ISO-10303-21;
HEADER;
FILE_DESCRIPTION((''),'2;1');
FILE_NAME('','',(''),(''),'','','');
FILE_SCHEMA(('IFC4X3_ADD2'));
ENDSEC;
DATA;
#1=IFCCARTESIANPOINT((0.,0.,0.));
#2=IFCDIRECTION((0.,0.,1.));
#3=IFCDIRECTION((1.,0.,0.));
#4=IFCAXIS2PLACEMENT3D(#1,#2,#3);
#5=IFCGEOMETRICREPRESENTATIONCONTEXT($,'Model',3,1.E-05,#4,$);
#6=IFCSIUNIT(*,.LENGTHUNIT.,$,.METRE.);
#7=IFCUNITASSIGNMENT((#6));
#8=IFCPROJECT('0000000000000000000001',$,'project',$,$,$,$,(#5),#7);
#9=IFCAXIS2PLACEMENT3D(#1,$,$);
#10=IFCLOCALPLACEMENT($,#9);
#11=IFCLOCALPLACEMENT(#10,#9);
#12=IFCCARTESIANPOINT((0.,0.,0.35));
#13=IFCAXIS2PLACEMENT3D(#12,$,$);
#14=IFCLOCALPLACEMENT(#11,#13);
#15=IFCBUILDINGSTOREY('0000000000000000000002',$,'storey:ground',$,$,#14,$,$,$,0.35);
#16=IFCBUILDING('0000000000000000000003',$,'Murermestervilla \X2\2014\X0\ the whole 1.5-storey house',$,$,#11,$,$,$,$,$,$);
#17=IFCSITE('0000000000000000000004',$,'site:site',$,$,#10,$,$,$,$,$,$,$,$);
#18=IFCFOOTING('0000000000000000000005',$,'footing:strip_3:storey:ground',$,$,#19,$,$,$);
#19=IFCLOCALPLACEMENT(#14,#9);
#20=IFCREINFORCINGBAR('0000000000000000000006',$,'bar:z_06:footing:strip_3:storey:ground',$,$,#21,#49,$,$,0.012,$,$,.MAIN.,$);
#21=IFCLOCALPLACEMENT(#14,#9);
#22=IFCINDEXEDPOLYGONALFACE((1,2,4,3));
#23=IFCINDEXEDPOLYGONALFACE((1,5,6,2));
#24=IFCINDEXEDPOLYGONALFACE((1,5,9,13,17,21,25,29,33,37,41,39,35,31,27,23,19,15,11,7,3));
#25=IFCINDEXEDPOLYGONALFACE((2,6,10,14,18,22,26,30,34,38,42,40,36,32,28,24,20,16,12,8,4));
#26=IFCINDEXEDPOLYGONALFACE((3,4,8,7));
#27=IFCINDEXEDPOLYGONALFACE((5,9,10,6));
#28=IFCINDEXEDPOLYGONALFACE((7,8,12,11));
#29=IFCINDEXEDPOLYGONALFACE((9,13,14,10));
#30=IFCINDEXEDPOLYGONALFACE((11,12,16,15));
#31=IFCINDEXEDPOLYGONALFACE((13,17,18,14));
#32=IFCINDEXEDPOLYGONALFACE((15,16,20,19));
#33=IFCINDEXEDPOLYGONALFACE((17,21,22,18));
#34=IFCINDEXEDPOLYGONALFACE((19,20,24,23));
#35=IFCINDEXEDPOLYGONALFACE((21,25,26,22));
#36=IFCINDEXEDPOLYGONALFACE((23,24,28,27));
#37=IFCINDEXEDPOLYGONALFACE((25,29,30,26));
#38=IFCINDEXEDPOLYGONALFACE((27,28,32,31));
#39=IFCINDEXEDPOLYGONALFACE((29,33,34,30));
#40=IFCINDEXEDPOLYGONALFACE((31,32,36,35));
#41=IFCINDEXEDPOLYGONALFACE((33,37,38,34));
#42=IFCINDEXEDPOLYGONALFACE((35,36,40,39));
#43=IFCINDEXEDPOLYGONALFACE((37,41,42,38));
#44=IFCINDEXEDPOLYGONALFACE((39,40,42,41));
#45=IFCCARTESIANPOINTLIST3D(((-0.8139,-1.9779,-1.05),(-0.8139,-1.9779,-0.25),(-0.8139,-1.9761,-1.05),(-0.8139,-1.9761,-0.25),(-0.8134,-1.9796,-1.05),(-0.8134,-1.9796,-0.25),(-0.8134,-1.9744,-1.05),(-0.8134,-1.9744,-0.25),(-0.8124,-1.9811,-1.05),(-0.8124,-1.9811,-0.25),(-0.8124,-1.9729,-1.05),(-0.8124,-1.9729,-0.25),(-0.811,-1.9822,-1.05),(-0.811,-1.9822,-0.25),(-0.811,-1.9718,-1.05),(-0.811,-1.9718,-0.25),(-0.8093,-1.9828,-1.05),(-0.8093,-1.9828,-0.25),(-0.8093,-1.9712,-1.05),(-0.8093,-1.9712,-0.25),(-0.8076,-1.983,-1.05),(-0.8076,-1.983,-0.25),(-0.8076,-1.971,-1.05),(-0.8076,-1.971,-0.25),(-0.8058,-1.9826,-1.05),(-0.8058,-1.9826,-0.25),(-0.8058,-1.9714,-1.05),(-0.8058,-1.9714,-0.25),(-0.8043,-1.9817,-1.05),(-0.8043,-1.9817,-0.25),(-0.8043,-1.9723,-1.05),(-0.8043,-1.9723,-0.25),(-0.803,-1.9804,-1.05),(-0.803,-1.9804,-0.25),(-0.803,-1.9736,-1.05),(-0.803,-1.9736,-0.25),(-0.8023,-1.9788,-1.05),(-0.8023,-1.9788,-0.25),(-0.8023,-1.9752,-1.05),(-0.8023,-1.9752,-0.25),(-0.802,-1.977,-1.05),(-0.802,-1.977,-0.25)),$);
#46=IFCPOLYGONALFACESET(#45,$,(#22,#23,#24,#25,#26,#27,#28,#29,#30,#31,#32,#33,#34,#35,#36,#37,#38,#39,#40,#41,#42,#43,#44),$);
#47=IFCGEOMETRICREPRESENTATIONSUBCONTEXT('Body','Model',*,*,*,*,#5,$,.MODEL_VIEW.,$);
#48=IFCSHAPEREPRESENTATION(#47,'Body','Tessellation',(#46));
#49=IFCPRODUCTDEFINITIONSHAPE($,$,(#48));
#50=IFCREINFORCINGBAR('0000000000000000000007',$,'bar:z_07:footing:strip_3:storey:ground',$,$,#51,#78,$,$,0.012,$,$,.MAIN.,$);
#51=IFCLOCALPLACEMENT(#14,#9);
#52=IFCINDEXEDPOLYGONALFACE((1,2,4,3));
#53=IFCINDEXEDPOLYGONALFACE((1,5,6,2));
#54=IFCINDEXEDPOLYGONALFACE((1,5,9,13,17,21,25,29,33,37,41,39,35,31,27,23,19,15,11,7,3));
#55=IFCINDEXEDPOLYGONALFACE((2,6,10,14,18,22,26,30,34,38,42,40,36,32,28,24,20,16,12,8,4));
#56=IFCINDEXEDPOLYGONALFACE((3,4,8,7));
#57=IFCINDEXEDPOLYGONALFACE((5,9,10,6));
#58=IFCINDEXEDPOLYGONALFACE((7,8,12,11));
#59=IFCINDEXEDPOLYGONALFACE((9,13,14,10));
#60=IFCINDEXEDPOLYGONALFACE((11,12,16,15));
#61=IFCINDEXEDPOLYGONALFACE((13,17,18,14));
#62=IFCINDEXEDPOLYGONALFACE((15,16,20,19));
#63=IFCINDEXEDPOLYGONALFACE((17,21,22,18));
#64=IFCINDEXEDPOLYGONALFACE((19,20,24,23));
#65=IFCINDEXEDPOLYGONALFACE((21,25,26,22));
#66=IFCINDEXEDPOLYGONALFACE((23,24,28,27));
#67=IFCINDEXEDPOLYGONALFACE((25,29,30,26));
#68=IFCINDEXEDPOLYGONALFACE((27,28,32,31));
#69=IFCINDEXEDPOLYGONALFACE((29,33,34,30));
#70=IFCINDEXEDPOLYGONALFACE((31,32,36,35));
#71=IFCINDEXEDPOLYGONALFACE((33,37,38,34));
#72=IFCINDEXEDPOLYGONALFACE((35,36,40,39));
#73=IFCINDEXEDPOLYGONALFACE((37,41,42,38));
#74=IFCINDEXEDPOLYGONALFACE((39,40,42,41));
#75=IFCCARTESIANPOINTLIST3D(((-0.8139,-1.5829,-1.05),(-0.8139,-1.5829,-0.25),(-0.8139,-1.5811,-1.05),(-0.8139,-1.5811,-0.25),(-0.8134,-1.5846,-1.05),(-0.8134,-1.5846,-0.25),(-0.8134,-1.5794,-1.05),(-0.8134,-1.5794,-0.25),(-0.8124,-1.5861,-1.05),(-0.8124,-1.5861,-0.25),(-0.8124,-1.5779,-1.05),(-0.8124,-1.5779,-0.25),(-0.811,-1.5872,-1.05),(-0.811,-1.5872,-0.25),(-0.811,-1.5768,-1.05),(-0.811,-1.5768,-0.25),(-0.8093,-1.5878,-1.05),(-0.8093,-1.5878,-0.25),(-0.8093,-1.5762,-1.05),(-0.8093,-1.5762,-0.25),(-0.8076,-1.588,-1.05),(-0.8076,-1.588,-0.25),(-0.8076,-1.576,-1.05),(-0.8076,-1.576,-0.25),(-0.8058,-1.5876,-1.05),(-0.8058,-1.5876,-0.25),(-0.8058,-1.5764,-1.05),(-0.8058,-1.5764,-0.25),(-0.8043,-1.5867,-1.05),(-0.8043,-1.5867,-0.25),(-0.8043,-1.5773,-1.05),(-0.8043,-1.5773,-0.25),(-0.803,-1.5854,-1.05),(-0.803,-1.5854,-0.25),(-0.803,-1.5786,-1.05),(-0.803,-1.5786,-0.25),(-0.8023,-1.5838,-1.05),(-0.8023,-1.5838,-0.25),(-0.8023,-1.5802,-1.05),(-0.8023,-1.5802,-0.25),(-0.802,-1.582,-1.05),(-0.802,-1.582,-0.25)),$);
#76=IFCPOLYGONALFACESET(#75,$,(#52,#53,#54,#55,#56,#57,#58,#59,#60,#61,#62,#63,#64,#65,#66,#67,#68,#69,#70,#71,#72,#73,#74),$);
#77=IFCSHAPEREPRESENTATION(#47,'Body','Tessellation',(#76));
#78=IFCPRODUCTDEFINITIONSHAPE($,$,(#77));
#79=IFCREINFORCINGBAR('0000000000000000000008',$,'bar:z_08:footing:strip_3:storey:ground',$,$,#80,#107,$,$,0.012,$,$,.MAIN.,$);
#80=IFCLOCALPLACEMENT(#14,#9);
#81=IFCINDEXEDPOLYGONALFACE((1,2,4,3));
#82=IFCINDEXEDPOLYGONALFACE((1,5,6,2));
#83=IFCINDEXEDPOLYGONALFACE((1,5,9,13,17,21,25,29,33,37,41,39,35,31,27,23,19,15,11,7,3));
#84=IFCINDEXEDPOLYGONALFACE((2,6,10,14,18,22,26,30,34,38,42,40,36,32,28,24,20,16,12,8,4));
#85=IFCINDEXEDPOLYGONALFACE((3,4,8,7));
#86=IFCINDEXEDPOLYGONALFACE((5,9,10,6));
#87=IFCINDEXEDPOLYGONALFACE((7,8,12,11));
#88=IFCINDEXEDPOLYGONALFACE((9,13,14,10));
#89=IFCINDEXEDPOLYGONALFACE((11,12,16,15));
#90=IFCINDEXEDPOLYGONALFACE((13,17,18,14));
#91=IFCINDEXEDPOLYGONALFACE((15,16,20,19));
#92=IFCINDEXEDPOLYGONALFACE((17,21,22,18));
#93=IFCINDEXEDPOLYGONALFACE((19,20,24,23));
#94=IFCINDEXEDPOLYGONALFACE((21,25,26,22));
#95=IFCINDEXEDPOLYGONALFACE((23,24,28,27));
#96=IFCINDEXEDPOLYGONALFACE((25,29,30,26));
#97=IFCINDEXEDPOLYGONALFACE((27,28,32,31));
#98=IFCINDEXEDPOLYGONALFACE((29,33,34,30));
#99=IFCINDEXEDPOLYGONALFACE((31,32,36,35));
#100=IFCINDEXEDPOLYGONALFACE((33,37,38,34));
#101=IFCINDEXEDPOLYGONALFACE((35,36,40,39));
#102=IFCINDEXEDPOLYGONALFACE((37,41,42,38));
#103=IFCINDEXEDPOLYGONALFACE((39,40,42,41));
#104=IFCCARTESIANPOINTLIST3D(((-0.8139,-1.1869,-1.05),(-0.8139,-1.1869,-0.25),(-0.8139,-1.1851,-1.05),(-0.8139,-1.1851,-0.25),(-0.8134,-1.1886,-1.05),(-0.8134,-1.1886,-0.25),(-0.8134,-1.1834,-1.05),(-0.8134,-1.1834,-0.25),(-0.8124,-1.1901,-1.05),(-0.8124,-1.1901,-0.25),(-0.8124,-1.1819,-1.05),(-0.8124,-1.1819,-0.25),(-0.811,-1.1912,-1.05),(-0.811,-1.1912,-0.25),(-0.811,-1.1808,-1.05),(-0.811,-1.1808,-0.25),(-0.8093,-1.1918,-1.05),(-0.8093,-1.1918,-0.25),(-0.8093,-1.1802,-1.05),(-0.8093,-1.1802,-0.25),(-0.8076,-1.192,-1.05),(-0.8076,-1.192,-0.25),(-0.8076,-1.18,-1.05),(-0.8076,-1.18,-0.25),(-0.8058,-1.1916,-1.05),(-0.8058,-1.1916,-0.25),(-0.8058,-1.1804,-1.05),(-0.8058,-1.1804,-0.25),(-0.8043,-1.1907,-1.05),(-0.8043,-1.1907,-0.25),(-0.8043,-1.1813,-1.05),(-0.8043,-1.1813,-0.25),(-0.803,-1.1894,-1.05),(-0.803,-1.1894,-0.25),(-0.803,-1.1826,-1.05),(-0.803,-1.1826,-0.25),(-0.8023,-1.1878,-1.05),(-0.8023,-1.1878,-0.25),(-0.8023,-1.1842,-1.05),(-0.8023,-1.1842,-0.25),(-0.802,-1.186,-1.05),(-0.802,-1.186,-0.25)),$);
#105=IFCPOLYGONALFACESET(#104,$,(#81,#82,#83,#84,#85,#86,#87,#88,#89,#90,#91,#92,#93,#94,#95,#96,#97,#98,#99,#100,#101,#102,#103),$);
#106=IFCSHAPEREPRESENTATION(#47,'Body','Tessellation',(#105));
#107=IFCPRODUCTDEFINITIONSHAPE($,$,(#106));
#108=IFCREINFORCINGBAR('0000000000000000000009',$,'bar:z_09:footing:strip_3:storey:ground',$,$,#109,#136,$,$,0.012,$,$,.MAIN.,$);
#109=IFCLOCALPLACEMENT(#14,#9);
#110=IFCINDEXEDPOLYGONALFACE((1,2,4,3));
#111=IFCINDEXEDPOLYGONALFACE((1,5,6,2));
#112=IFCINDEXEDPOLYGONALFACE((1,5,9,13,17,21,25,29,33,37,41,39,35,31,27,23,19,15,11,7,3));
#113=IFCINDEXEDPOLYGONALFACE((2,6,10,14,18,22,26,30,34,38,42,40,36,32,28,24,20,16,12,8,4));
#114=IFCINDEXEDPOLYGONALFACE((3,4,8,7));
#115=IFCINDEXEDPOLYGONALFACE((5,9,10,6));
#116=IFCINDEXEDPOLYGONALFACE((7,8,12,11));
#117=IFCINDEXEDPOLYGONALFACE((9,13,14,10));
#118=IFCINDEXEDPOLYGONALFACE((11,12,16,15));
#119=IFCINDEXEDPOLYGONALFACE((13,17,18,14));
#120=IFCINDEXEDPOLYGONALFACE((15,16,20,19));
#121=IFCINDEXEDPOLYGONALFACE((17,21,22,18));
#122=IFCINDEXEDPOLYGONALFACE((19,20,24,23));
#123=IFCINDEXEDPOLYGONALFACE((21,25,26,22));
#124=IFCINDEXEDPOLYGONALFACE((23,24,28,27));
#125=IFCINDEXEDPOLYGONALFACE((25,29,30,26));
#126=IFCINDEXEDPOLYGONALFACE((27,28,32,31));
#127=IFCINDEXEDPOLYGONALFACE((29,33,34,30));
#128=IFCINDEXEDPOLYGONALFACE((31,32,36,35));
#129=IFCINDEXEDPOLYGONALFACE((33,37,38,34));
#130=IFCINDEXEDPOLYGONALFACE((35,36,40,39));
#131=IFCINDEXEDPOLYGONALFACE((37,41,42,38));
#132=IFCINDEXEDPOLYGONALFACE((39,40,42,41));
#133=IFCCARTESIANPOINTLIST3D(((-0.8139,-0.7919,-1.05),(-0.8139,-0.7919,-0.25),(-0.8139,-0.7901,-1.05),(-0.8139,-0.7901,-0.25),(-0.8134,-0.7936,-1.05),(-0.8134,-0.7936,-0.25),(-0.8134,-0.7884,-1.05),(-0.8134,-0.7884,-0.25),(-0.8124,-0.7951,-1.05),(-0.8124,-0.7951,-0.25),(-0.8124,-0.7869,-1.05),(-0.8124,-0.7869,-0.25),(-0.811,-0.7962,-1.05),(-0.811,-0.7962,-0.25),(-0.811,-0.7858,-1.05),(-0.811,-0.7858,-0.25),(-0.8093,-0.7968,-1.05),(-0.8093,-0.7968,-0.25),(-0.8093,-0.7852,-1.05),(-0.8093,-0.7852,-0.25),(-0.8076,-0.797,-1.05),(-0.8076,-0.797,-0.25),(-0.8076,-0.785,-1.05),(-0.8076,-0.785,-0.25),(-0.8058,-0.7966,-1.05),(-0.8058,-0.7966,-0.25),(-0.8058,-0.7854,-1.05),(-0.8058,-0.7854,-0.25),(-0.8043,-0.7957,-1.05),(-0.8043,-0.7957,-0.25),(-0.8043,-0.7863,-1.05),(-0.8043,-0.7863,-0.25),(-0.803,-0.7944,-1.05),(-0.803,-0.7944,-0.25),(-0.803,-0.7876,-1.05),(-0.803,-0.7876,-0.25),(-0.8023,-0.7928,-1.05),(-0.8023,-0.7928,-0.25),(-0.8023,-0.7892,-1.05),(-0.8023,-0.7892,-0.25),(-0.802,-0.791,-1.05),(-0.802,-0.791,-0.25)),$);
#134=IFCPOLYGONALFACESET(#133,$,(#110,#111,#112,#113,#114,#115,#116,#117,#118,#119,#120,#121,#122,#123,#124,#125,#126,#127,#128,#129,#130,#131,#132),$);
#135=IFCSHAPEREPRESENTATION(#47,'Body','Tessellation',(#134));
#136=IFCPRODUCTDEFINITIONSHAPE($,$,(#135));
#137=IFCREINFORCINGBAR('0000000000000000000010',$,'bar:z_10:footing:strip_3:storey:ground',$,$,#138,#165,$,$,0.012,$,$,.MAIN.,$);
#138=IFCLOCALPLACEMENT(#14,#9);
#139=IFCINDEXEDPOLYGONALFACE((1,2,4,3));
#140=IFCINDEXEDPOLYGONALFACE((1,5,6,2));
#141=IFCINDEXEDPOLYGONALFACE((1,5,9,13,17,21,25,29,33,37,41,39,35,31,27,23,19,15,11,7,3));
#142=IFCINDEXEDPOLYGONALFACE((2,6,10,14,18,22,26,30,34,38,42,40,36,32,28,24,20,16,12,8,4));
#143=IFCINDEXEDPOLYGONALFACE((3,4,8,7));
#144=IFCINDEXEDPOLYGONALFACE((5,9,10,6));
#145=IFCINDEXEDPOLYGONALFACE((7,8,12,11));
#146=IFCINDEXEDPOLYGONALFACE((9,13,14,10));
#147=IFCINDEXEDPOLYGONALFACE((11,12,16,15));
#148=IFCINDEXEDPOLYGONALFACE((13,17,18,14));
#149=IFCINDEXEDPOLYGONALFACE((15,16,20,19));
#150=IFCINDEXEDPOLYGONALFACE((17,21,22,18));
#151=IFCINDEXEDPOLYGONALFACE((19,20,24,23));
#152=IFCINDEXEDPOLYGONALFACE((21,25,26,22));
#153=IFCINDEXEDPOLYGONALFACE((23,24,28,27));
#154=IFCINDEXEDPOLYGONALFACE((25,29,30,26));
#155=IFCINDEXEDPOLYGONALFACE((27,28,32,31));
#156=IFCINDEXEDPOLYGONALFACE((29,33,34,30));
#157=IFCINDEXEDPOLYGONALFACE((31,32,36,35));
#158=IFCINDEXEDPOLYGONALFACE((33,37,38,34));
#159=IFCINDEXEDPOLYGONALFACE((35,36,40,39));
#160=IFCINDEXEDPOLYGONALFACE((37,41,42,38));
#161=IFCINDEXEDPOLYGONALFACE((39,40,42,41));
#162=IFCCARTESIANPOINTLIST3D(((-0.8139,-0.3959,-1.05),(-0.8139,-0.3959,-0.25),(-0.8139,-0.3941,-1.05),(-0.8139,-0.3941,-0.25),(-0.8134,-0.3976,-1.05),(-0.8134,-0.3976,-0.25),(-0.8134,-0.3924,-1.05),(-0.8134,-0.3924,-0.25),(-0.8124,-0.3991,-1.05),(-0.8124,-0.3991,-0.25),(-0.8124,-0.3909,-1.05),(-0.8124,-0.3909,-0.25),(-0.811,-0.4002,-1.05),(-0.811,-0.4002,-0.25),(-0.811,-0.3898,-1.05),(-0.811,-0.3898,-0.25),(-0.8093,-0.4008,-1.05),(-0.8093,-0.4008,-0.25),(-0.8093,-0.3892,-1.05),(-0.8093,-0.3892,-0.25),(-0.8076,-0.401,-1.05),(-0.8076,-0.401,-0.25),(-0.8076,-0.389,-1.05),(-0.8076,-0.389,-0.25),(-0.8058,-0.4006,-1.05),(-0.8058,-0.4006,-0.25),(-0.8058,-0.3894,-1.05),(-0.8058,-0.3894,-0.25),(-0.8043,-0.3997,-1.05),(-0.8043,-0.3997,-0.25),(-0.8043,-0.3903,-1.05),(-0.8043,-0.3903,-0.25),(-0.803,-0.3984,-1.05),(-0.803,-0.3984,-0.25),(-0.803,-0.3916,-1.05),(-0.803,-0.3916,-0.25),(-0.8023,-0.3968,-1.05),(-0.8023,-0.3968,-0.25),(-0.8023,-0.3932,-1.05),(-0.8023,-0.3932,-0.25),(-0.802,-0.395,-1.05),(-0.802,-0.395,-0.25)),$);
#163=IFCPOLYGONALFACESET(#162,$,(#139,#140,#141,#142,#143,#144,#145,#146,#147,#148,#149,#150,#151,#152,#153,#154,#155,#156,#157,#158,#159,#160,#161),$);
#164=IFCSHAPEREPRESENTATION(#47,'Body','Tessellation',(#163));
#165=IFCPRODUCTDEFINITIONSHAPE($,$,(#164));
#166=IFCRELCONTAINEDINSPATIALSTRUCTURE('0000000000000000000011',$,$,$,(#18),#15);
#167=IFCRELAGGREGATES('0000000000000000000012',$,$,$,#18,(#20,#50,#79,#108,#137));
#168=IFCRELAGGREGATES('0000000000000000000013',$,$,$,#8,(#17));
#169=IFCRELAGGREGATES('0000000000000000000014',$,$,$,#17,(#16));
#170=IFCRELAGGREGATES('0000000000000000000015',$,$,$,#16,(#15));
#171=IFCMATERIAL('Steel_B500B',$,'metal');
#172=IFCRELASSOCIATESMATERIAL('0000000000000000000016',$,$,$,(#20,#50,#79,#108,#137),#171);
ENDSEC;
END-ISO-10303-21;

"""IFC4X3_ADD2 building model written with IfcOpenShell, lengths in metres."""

from ifc_helpers import new_model, entity, si_unit, frame, origin, origin_with_axes, place, context, subcontext, project, spatial, material, element, aggregate, save


model = new_model("IFC4X3_ADD2")

# Units and contexts
model_context = context("Model", 3, precision=1e-05, world=origin_with_axes())
body_context = subcontext(model_context, "Body", "Model", "MODEL_VIEW")
ifc_project = project(units=[si_unit("LENGTHUNIT", "METRE")], contexts=[model_context])

# Site, building, storey
placement = place(None, origin())
site = spatial("IfcSite", under=ifc_project, at=placement, Name="site:site")
building_placement = place(placement, origin())
building = spatial("IfcBuilding", under=site, at=building_placement, Name="Murermestervilla — the whole 1.5-storey house")
storey_placement = place(building_placement, frame((0.0, 0.0, 0.35)))
storey = spatial("IfcBuildingStorey", under=building, at=storey_placement, Name="storey:ground", Elevation=0.35)

# Footing, reinforcing bars
footing_placement = place(storey_placement, frame((0.0, 0.0, -0.35)))
footing = element("IfcFooting", 1, at=footing_placement, inside=storey, Name="footing:strip_3:storey:ground")
ifc_material = material(Name="Steel_B500B", Category="metal")
reinforcing_bar_1 = element("IfcReinforcingBar", 2, at=placement, material=ifc_material, Name="bar:z_06:footing:strip_3:storey:ground", NominalDiameter=0.012, PredefinedType="MAIN", context=body_context, shape_type="AdvancedSweptSolid", body=[
    entity("IfcSweptDiskSolid", entity("IfcPolyline", [entity("IfcCartesianPoint", [-0.808, -1.977, -0.7]), entity("IfcCartesianPoint", [-0.808, -1.977, 0.1])]), 0.006),
])
reinforcing_bar_2 = element("IfcReinforcingBar", 3, at=placement, material=ifc_material, Name="bar:z_07:footing:strip_3:storey:ground", NominalDiameter=0.012, PredefinedType="MAIN", context=body_context, shape_type="AdvancedSweptSolid", body=[
    entity("IfcSweptDiskSolid", entity("IfcPolyline", [entity("IfcCartesianPoint", [-0.808, -1.582, -0.7]), entity("IfcCartesianPoint", [-0.808, -1.582, 0.1])]), 0.006),
])
reinforcing_bar_3 = element("IfcReinforcingBar", 4, at=placement, material=ifc_material, Name="bar:z_08:footing:strip_3:storey:ground", NominalDiameter=0.012, PredefinedType="MAIN", context=body_context, shape_type="AdvancedSweptSolid", body=[
    entity("IfcSweptDiskSolid", entity("IfcPolyline", [entity("IfcCartesianPoint", [-0.808, -1.186, -0.7]), entity("IfcCartesianPoint", [-0.808, -1.186, 0.1])]), 0.006),
])
reinforcing_bar_4 = element("IfcReinforcingBar", 5, at=placement, material=ifc_material, Name="bar:z_09:footing:strip_3:storey:ground", NominalDiameter=0.012, PredefinedType="MAIN", context=body_context, shape_type="AdvancedSweptSolid", body=[
    entity("IfcSweptDiskSolid", entity("IfcPolyline", [entity("IfcCartesianPoint", [-0.808, -0.791, -0.7]), entity("IfcCartesianPoint", [-0.808, -0.791, 0.1])]), 0.006),
])
reinforcing_bar_5 = element("IfcReinforcingBar", 6, at=placement, material=ifc_material, Name="bar:z_10:footing:strip_3:storey:ground", NominalDiameter=0.012, PredefinedType="MAIN", context=body_context, shape_type="AdvancedSweptSolid", body=[
    entity("IfcSweptDiskSolid", entity("IfcPolyline", [entity("IfcCartesianPoint", [-0.808, -0.395, -0.7]), entity("IfcCartesianPoint", [-0.808, -0.395, 0.1])]), 0.006),
])
aggregate(footing, [reinforcing_bar_1, reinforcing_bar_2, reinforcing_bar_3, reinforcing_bar_4, reinforcing_bar_5])

save(model, "model.ifc")
